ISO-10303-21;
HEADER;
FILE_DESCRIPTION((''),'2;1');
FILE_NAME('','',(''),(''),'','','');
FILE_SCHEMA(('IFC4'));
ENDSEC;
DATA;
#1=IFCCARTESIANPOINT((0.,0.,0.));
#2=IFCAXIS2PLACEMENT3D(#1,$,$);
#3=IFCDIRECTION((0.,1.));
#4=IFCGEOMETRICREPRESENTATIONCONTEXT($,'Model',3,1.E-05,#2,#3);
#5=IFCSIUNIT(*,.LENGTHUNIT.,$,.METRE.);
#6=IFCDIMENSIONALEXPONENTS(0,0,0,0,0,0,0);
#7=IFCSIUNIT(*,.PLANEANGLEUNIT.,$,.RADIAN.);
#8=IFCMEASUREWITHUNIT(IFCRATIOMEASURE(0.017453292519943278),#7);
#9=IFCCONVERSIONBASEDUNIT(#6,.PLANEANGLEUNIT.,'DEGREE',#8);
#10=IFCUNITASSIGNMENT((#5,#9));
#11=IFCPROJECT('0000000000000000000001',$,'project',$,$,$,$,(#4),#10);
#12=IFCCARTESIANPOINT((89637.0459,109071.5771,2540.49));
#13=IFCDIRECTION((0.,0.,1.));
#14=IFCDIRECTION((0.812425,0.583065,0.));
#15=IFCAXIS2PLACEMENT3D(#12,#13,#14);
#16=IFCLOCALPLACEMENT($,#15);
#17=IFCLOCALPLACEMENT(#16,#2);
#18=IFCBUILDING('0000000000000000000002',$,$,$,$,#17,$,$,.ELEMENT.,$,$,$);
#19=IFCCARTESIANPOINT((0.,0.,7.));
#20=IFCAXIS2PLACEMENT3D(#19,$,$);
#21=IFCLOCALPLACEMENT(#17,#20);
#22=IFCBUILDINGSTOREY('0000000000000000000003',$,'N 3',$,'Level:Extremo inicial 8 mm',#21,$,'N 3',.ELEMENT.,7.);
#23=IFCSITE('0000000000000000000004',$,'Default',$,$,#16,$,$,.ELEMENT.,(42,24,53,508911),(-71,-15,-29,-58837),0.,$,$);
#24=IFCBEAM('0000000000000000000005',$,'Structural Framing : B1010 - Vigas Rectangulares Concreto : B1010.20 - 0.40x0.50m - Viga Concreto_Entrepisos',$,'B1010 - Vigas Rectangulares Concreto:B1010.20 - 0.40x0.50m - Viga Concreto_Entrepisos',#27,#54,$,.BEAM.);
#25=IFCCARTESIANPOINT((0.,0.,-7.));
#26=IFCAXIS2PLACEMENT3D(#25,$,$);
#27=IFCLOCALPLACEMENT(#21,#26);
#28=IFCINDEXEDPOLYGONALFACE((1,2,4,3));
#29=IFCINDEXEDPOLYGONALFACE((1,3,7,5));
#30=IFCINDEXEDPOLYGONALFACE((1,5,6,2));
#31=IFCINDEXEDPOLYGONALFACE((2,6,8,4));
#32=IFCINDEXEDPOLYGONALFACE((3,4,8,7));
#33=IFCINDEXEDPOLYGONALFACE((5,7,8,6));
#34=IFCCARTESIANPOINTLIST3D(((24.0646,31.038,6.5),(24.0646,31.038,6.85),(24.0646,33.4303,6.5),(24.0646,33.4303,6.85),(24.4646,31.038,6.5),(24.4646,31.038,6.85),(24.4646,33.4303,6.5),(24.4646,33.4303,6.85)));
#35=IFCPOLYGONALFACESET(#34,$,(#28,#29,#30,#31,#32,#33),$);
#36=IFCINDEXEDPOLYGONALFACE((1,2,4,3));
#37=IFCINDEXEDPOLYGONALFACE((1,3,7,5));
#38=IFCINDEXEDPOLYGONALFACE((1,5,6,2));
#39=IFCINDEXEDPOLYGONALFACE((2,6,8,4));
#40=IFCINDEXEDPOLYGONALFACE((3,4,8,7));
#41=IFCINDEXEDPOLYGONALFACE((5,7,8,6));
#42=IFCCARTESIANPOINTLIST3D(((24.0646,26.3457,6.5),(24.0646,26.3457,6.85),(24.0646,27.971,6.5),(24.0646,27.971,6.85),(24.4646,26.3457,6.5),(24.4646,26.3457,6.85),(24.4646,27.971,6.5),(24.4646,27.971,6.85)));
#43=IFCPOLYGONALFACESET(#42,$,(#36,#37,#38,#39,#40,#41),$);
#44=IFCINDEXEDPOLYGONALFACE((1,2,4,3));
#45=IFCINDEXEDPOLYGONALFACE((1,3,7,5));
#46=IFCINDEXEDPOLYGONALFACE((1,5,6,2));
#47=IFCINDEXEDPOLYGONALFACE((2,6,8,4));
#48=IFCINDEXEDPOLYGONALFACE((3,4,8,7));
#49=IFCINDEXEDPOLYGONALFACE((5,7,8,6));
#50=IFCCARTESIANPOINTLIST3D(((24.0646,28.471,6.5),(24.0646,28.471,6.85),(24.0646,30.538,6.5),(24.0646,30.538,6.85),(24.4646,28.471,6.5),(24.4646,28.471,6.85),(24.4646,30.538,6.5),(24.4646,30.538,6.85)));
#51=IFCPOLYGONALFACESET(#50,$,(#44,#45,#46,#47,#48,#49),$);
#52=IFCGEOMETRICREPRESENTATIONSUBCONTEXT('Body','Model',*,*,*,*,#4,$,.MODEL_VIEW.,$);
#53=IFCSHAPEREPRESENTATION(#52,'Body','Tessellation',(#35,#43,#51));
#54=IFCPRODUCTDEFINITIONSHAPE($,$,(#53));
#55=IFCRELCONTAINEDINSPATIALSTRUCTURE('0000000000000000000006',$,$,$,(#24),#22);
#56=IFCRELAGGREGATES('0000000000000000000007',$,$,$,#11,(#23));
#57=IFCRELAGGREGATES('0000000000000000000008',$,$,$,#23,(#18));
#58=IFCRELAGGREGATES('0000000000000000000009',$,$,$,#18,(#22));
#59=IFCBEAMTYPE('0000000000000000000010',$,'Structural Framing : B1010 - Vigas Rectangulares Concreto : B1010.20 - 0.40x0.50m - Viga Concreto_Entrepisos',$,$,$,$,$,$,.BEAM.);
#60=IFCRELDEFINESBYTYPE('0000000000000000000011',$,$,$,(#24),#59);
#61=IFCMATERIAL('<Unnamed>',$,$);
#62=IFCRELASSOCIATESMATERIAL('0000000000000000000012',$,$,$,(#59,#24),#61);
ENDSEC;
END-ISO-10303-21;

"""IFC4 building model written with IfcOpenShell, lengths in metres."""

from ifc_helpers import new_model, entity, si_unit, converted_unit, direction, frame, frame_2d, origin, place, context, subcontext, project, spatial, polyline, segment, composite_curve, rectangle, outline, extrude, source, transform, mapped, material, material_profile, profile_set, profile_usage, type_object, type_shapes, element, save


model = new_model("IFC4")

# Units and contexts
model_context = context("Model", 3, precision=1e-05, world=origin(), true_north=direction((0.0, 1.0)))
body_context = subcontext(model_context, "Body", "Model", "MODEL_VIEW")
ifc_project = project(units=[si_unit("LENGTHUNIT", "METRE"), converted_unit("PLANEANGLEUNIT", "DEGREE", entity("IfcRatioMeasure", 0.017453292519943278), si_unit("PLANEANGLEUNIT", "RADIAN"), dimensions=[0, 0, 0, 0, 0, 0, 0])], contexts=[model_context])

# Site, building, storey
site_placement = place(None, frame((89637.0459, 109071.5771, 2540.49), z_axis=(0.0, 0.0, 1.0), x_axis=(0.812425, 0.583065, 0.0)))
site = spatial("IfcSite", under=ifc_project, at=site_placement, Name="Default", CompositionType="ELEMENT", RefLatitude=(42, 24, 53, 508911), RefLongitude=(-71, -15, -29, -58837), RefElevation=0.0)
building_placement = place(site_placement, origin())
building = spatial("IfcBuilding", under=site, at=building_placement, CompositionType="ELEMENT")
storey_placement = place(building_placement, frame((0.0, 0.0, 7.0)))
storey = spatial("IfcBuildingStorey", under=building, at=storey_placement, Name="N 3", ObjectType="Level:Extremo inicial 8 mm", LongName="N 3", CompositionType="ELEMENT", Elevation=7.0)

# Beam
ifc_material_1 = material(Name="<Unnamed>")
ifc_material_profile_1 = material_profile(ifc_material_1, outline(composite_curve([segment(polyline([(-0.2, -0.25, 0.0), (-0.2, 0.1, 0.0)]), True, "CONTINUOUS"), segment(polyline([(-0.2, 0.1, 0.0), (0.2, 0.1, 0.0)]), True, "CONTINUOUS"), segment(polyline([(0.2, 0.1, 0.0), (0.2, -0.25, 0.0)]), True, "CONTINUOUS"), segment(polyline([(0.2, -0.25, 0.0), (-0.2, -0.25, 0.0)]), True, "CONTINUOUS")], self_intersect=False), kind="CURVE"), Name="B1010.20 - 0.40x0.50m - Viga Concreto_Entrepisos")
ifc_material_profile_2 = material_profile(ifc_material_1, outline(composite_curve([segment(polyline([(-7.8238, -0.2, 0.25), (-7.8238, 0.2, 0.25)]), True, "CONTINUOUS"), segment(polyline([(-7.8238, 0.2, 0.25), (-7.8238, 0.2, -0.25)]), True, "CONTINUOUS"), segment(polyline([(-7.8238, 0.2, -0.25), (-7.8238, -0.2, -0.25)]), True, "CONTINUOUS"), segment(polyline([(-7.8238, -0.2, -0.25), (-7.8238, -0.2, 0.25)]), True, "CONTINUOUS")], self_intersect=False), kind="CURVE"), Name="B1010.20 - 0.40x0.50m - Viga Concreto_Entrepisos")
ifc_profile_set_1 = profile_set([ifc_material_profile_1, ifc_material_profile_2], Name="B1010.20 - 0.40x0.50m - Viga Concreto_Entrepisos")
ifc_profile_usage_1 = profile_usage(ifc_profile_set_1, cardinal=8)
beam_type_1 = type_object("IfcBeamType", Name="Structural Framing : B1010 - Vigas Rectangulares Concreto : B1010.20 - 0.40x0.50m - Viga Concreto_Entrepisos", PredefinedType="BEAM", material=ifc_profile_set_1)
shared_shape_1 = source(origin(), body_context, "Body", "SweptSolid", [
    extrude(rectangle(XDim=0.35, YDim=0.4, at=frame_2d((0.0, 0.0), x_axis=(0.0, 1.0))), frame((24.2646, 31.038, 6.675), z_axis=(0.0, 1.0, 0.0), x_axis=(-1.0, 0.0, 0.0)), (0.0, 0.0, 1.0), 2.3923),
    extrude(rectangle(XDim=0.35, YDim=0.4, at=frame_2d((0.0, 0.0), x_axis=(0.0, 1.0))), frame((24.2646, 26.3457, 6.675), z_axis=(0.0, 1.0, 0.0), x_axis=(-1.0, 0.0, 0.0)), (0.0, 0.0, 1.0), 1.6253),
    extrude(rectangle(XDim=0.35, YDim=0.4, at=frame_2d((0.0, 0.0), x_axis=(0.0, 1.0))), frame((24.2646, 28.471, 6.675), z_axis=(0.0, 1.0, 0.0), x_axis=(-1.0, 0.0, 0.0)), (0.0, 0.0, 1.0), 2.0671),
])
type_shapes(beam_type_1, [shared_shape_1])
beam_1_placement = place(storey_placement, frame((0.0, 0.0, -7.0)))
element("IfcBeam", 1, at=beam_1_placement, inside=storey, type_object=beam_type_1, material=ifc_profile_usage_1, Name="Structural Framing : B1010 - Vigas Rectangulares Concreto : B1010.20 - 0.40x0.50m - Viga Concreto_Entrepisos", ObjectType="B1010 - Vigas Rectangulares Concreto:B1010.20 - 0.40x0.50m - Viga Concreto_Entrepisos", PredefinedType="BEAM", context=body_context, shape_type="MappedRepresentation", body=[
    mapped(shared_shape_1, transform((0.0, 0.0, 0.0), scale=1.0)),
])

save(model, "model.ifc")
